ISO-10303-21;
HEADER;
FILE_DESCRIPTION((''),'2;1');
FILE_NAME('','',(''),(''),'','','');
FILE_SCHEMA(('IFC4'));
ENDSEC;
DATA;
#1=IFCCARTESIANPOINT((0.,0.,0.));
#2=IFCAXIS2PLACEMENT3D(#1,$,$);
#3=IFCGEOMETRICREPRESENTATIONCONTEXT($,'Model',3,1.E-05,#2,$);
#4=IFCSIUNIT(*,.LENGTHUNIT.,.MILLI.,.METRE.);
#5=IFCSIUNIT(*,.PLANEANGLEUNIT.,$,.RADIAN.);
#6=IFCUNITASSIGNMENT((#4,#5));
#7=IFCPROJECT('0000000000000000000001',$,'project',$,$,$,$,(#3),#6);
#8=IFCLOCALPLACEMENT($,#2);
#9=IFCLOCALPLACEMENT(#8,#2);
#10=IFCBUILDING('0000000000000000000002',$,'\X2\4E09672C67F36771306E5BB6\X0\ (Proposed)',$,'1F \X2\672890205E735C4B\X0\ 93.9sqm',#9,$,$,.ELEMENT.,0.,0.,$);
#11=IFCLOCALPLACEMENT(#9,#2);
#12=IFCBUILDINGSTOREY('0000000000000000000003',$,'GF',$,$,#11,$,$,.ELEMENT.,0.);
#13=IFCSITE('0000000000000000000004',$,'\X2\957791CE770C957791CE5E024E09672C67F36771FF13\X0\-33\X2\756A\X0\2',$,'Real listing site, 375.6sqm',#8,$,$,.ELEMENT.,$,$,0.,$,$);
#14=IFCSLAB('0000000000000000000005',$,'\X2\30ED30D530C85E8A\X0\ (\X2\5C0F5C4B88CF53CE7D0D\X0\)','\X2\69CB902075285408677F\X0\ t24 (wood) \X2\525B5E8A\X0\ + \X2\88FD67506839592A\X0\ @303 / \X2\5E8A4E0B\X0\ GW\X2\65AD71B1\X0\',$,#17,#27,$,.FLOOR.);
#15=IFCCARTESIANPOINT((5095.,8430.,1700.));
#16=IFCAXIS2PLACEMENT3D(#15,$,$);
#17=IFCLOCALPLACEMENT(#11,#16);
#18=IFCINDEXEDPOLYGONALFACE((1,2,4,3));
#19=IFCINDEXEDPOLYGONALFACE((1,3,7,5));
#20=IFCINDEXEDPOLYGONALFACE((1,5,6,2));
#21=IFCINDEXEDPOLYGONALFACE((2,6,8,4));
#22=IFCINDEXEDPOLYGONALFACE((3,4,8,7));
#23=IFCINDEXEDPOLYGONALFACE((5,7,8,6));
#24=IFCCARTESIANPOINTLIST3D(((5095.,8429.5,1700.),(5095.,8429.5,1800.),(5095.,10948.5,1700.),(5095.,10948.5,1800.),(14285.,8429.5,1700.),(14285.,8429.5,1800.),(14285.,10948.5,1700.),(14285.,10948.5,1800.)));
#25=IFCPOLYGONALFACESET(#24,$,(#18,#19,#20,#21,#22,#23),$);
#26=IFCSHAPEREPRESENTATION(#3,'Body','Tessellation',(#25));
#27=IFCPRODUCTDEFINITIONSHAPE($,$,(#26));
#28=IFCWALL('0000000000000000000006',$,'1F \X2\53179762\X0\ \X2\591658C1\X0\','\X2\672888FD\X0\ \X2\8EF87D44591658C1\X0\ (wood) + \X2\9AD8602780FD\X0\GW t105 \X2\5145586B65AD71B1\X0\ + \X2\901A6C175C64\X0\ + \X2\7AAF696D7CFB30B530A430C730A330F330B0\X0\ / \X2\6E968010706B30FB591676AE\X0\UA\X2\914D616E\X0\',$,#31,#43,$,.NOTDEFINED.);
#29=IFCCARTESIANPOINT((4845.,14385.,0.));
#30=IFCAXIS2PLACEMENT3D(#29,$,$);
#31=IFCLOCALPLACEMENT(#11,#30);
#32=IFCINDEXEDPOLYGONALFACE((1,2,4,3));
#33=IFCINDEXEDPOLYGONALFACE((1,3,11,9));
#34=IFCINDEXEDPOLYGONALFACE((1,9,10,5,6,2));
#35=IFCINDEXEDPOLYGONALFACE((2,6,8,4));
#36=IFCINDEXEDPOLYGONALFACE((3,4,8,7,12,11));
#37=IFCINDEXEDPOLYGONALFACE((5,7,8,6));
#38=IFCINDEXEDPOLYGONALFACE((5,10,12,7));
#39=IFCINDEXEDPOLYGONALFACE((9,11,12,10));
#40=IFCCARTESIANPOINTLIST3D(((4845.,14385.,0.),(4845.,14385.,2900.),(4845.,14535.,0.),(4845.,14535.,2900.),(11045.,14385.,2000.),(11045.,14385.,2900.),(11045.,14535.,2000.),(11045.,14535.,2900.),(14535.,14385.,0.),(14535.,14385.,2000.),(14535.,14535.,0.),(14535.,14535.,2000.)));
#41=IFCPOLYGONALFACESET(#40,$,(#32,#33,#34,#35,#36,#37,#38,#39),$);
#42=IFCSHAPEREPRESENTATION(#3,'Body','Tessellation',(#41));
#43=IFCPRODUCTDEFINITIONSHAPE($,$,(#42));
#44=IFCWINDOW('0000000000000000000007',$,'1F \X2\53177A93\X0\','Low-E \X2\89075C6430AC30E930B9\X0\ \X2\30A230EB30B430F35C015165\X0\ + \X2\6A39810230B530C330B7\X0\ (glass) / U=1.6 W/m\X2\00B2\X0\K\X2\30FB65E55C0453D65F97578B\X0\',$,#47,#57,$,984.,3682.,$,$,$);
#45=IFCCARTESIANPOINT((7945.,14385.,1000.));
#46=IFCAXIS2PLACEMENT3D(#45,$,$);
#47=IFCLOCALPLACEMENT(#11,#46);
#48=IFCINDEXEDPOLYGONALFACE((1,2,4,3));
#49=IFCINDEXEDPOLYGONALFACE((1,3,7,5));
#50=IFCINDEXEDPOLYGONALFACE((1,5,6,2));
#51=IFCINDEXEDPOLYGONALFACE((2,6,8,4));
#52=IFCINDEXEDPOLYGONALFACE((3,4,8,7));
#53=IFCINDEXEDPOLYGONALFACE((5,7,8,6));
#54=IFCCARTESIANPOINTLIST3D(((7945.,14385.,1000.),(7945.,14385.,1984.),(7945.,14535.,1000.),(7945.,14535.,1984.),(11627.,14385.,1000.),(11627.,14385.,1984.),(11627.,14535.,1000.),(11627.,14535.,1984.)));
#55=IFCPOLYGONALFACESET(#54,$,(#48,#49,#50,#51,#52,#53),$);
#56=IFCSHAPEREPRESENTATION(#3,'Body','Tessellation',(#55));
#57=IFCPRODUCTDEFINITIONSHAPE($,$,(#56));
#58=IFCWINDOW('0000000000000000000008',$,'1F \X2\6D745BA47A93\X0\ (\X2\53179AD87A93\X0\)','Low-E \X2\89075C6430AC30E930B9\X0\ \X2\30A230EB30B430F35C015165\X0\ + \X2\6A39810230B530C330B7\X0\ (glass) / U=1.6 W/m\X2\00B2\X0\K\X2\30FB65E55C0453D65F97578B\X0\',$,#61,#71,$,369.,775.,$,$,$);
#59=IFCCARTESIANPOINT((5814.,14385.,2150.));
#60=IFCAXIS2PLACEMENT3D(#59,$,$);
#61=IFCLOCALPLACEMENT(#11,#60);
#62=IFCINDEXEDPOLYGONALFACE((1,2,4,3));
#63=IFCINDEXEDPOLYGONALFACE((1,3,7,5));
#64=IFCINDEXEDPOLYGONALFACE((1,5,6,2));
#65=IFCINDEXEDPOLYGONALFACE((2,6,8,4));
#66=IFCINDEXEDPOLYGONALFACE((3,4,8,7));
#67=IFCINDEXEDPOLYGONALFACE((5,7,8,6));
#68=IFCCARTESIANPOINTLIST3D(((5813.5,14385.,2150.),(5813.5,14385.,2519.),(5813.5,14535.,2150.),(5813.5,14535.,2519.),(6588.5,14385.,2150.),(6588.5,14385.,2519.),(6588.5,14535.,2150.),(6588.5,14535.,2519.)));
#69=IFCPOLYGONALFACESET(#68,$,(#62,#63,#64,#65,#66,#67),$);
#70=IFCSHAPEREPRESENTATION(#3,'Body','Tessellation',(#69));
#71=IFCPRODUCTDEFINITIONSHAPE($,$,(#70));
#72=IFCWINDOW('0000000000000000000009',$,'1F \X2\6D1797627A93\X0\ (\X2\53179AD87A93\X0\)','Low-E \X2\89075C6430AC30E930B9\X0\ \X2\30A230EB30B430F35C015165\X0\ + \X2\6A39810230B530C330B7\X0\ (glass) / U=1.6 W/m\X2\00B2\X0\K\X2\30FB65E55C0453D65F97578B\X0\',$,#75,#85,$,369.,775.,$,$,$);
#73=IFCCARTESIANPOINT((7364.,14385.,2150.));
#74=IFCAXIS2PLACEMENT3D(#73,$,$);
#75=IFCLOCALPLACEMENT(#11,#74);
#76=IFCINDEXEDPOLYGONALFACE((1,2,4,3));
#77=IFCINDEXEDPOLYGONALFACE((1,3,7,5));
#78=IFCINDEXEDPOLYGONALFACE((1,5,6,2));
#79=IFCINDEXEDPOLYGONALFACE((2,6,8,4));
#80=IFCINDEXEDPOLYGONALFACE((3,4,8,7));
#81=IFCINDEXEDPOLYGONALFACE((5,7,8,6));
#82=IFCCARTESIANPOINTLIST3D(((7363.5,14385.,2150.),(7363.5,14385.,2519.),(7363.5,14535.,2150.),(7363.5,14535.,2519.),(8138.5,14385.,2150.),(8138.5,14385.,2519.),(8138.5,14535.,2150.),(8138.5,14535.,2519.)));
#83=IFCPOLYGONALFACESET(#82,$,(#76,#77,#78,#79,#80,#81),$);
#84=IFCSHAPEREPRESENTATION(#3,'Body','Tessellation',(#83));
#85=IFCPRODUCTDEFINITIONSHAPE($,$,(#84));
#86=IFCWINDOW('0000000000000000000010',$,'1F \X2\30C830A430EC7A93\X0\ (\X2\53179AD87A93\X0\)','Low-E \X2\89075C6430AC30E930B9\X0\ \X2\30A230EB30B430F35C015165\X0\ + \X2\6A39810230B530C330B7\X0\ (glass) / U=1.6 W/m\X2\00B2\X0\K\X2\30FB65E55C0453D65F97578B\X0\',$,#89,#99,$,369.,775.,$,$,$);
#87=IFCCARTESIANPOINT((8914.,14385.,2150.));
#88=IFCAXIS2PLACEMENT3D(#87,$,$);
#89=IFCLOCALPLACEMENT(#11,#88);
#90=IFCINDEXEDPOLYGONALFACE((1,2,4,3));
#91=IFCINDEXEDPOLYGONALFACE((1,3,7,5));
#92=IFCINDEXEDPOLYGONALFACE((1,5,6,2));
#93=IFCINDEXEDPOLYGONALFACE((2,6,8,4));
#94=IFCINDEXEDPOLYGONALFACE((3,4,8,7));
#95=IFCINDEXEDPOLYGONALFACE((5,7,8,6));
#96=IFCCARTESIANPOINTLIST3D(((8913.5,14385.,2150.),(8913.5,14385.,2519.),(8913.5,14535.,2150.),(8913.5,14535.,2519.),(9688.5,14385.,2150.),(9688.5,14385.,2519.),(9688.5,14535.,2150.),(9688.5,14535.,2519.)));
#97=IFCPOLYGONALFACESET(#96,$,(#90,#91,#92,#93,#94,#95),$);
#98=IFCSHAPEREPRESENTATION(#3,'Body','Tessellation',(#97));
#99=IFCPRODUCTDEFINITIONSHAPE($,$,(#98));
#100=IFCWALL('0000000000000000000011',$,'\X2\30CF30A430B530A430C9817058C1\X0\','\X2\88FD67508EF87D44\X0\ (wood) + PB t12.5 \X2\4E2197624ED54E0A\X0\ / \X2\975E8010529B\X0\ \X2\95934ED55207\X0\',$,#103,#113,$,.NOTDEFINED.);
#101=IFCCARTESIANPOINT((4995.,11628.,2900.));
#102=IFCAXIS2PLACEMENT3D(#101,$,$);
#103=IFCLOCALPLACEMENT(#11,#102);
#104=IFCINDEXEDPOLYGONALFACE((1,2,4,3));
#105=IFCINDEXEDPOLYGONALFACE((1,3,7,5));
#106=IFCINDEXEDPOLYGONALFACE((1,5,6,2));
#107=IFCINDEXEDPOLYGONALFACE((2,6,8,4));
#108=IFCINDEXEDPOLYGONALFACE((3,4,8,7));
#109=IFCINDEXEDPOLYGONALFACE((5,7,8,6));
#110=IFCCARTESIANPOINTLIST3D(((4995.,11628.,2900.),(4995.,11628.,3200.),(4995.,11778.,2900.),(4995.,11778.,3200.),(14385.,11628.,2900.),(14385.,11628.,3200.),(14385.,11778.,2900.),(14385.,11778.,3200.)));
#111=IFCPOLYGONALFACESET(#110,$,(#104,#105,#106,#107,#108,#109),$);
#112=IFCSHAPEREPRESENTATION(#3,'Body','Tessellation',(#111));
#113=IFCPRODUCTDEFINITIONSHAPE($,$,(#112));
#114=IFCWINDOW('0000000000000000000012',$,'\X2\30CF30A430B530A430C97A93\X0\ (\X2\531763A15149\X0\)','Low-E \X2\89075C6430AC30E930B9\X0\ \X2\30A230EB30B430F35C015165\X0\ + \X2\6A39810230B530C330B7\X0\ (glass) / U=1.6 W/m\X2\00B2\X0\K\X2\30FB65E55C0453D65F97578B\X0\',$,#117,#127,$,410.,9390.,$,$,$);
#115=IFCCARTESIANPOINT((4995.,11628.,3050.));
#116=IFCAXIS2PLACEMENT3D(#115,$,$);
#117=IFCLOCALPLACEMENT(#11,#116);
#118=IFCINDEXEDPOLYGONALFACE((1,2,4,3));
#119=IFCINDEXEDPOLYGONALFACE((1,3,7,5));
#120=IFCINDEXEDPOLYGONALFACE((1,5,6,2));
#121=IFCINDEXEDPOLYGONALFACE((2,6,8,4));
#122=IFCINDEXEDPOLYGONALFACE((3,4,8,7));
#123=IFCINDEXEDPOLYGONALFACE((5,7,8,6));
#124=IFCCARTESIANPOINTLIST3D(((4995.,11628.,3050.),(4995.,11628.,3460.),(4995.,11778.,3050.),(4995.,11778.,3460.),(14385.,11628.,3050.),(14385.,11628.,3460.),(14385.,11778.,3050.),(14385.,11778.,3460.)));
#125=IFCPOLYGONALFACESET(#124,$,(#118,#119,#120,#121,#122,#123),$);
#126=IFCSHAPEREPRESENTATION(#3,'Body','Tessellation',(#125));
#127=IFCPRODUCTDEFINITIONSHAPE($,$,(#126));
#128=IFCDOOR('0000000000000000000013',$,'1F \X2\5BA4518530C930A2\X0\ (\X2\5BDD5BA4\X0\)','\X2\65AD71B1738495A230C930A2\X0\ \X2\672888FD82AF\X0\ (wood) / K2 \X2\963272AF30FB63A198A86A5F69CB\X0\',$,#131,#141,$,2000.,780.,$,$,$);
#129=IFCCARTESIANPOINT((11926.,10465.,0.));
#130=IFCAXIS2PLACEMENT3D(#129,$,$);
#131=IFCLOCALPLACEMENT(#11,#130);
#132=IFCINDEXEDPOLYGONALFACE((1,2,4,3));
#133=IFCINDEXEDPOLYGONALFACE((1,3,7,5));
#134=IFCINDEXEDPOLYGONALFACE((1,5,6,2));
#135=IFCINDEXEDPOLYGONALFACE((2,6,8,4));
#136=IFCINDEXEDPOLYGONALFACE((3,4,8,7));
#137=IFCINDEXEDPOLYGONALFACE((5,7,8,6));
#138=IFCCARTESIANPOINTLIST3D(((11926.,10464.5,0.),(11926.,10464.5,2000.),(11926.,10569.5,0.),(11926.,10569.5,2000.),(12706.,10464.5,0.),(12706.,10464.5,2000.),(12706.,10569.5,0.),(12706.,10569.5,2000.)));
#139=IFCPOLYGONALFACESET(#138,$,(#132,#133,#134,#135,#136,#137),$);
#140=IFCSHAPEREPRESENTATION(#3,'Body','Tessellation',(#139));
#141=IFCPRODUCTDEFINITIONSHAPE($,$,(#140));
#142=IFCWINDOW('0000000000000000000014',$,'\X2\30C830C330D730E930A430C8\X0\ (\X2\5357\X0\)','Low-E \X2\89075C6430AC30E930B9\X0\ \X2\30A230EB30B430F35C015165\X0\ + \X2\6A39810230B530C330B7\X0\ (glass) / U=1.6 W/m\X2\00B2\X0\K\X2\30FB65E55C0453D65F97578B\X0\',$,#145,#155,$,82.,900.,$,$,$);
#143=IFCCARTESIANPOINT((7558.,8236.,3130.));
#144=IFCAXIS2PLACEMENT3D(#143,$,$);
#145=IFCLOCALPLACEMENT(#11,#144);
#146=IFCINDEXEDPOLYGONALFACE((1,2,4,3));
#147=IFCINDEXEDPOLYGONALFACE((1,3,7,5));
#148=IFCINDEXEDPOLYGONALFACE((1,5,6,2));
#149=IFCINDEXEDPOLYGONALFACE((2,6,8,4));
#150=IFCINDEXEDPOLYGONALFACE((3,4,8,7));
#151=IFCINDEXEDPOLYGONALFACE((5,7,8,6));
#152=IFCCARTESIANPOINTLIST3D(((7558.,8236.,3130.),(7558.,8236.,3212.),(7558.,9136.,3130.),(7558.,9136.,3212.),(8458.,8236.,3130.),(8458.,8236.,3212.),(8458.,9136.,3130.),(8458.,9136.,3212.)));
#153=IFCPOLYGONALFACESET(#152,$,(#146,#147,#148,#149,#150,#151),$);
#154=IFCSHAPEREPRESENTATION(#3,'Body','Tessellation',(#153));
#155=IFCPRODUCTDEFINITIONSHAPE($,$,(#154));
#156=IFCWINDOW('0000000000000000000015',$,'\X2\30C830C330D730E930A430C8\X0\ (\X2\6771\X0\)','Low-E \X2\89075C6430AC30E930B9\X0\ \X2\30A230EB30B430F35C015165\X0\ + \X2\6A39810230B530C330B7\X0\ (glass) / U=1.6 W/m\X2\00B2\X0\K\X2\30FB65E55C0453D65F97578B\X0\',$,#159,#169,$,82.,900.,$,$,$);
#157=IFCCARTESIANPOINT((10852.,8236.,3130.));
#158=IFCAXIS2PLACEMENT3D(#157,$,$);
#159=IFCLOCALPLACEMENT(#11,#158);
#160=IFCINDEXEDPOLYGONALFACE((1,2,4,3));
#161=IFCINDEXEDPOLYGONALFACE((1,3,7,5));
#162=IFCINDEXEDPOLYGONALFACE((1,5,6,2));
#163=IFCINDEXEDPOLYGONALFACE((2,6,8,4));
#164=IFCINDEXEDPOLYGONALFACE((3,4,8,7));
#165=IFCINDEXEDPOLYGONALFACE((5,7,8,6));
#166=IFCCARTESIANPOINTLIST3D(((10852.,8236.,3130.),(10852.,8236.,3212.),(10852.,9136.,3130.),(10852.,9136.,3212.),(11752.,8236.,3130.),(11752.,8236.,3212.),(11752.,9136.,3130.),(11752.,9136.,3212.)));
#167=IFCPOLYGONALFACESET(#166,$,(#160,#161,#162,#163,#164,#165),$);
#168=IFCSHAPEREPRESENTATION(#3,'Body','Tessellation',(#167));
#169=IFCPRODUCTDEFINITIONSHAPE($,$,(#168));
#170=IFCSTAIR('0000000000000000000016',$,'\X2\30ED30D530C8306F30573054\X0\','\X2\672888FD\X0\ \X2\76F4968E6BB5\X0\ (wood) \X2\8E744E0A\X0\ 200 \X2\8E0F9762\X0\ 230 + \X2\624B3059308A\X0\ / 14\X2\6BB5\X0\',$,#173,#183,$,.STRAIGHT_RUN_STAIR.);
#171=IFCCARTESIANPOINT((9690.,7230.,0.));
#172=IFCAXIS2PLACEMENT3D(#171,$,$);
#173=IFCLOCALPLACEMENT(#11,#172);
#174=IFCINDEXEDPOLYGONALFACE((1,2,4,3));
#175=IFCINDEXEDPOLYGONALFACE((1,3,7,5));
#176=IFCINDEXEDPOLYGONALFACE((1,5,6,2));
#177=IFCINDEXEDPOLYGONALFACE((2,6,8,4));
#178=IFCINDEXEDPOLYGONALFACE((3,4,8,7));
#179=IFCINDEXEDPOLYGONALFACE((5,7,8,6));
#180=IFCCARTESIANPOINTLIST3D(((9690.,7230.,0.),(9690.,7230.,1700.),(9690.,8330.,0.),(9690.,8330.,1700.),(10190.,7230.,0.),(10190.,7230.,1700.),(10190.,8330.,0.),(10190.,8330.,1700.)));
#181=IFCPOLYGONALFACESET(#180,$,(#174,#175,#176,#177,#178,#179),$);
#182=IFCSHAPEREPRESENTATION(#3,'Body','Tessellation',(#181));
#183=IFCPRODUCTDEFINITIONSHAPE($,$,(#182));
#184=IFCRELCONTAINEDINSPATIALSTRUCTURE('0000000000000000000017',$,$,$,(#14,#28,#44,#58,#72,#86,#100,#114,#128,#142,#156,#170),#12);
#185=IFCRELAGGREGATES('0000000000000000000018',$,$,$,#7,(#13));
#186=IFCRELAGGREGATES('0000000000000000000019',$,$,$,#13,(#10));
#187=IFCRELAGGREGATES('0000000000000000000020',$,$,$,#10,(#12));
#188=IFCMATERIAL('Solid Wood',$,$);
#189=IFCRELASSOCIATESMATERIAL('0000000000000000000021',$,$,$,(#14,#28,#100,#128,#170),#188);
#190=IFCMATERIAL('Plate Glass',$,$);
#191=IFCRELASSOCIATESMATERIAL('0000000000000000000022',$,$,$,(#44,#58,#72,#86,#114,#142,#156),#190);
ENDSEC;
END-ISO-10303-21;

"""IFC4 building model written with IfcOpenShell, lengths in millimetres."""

from ifc_helpers import new_model, si_unit, frame, frame_2d, origin, place, context, project, spatial, rectangle, extrude, material, element, fill, save


model = new_model("IFC4")

# Units and contexts
model_context = context("Model", 3, precision=1e-05, world=origin())
ifc_project = project(units=[si_unit("LENGTHUNIT", "METRE", prefix="MILLI"), si_unit("PLANEANGLEUNIT", "RADIAN")], contexts=[model_context])

# Site, building, storey
site_placement = place(None, origin())
site = spatial("IfcSite", under=ifc_project, at=site_placement, Name="長野県長野市三本柳東３-33番2", ObjectType="Real listing site, 375.6sqm", CompositionType="ELEMENT", RefElevation=0.0)
building_placement = place(site_placement, origin())
building = spatial("IfcBuilding", under=site, at=building_placement, Name="三本柳東の家 (Proposed)", ObjectType="1F 木造平屋 93.9sqm", CompositionType="ELEMENT", ElevationOfRefHeight=0.0, ElevationOfTerrain=0.0)
storey_placement = place(building_placement, origin())
storey = spatial("IfcBuildingStorey", under=building, at=storey_placement, Name="GF", CompositionType="ELEMENT", Elevation=0.0)

# Slab
ifc_material_1 = material(Name="Solid Wood")
slab_placement = place(storey_placement, frame((5095.0, 8430.0, 1700.0)))
element("IfcSlab", 1, at=slab_placement, inside=storey, material=ifc_material_1, Name="ロフト床 (小屋裏収納)", Description="構造用合板 t24 (wood) 剛床 + 製材根太 @303 / 床下 GW断熱", PredefinedType="FLOOR", context=model_context, shape_type="SweptSolid", body=[
    extrude(rectangle(XDim=9190.0, YDim=2519.0, at=frame_2d((4595.0, 1259.0))), frame((5095.0, 8430.0, 1700.0)), (0.0, 0.0, 1.0), 100.0),
])

# Wall, openings, windows
wall_1_placement = place(storey_placement, frame((4845.0, 14385.0, 0.0)))
wall_1 = element("IfcWall", 2, at=wall_1_placement, inside=storey, material=ifc_material_1, Name="1F 北面 外壁", Description="木製 軸組外壁 (wood) + 高性能GW t105 充填断熱 + 通気層 + 窯業系サイディング / 準耐火・外皮UA配慮", PredefinedType="NOTDEFINED", context=model_context, shape_type="SweptSolid", body=[
    extrude(rectangle(XDim=9690.0, YDim=150.0, at=frame_2d((4845.0, 75.0))), frame((4845.0, 14385.0, 0.0)), (0.0, 0.0, 1.0), 2900.0),
])
opening_1_placement = place(storey_placement, frame((7945.0, 14385.0, 1000.0)))
opening_1 = element("IfcOpeningElement", 3, at=opening_1_placement, cuts=wall_1, PredefinedType="NOTDEFINED", context=model_context, shape_type="SweptSolid", body=[
    extrude(rectangle(XDim=3682.0, YDim=150.0, at=frame_2d((1841.0, 75.0))), frame((7945.0, 14385.0, 1000.0)), (0.0, 0.0, 1.0), 984.0),
])
opening_2_placement = place(storey_placement, frame((5814.0, 14385.0, 2150.0)))
opening_2 = element("IfcOpeningElement", 4, at=opening_2_placement, cuts=wall_1, PredefinedType="NOTDEFINED", context=model_context, shape_type="SweptSolid", body=[
    extrude(rectangle(XDim=775.0, YDim=150.0, at=frame_2d((387.0, 75.0))), frame((5814.0, 14385.0, 2150.0)), (0.0, 0.0, 1.0), 369.0),
])
opening_3_placement = place(storey_placement, frame((7364.0, 14385.0, 2150.0)))
opening_3 = element("IfcOpeningElement", 5, at=opening_3_placement, cuts=wall_1, PredefinedType="NOTDEFINED", context=model_context, shape_type="SweptSolid", body=[
    extrude(rectangle(XDim=775.0, YDim=150.0, at=frame_2d((387.0, 75.0))), frame((7364.0, 14385.0, 2150.0)), (0.0, 0.0, 1.0), 369.0),
])
opening_4_placement = place(storey_placement, frame((8914.0, 14385.0, 2150.0)))
opening_4 = element("IfcOpeningElement", 6, at=opening_4_placement, cuts=wall_1, PredefinedType="NOTDEFINED", context=model_context, shape_type="SweptSolid", body=[
    extrude(rectangle(XDim=775.0, YDim=150.0, at=frame_2d((387.0, 75.0))), frame((8914.0, 14385.0, 2150.0)), (0.0, 0.0, 1.0), 369.0),
])
ifc_material_2 = material(Name="Plate Glass")
window_1_placement = place(storey_placement, frame((7945.0, 14385.0, 1000.0)))
window_1 = element("IfcWindow", 7, at=window_1_placement, inside=storey, material=ifc_material_2, Name="1F 北窓", Description="Low-E 複層ガラス アルゴン封入 + 樹脂サッシ (glass) / U=1.6 W/m²K・日射取得型", OverallHeight=984.0, OverallWidth=3682.0, context=model_context, shape_type="SweptSolid", body=[
    extrude(rectangle(XDim=3682.0, YDim=150.0, at=frame_2d((1841.0, 75.0))), frame((7945.0, 14385.0, 1000.0)), (0.0, 0.0, 1.0), 984.0),
])
fill(opening_1, window_1)
window_2_placement = place(storey_placement, frame((5814.0, 14385.0, 2150.0)))
window_2 = element("IfcWindow", 8, at=window_2_placement, inside=storey, material=ifc_material_2, Name="1F 浴室窓 (北高窓)", Description="Low-E 複層ガラス アルゴン封入 + 樹脂サッシ (glass) / U=1.6 W/m²K・日射取得型", OverallHeight=369.0, OverallWidth=775.0, context=model_context, shape_type="SweptSolid", body=[
    extrude(rectangle(XDim=775.0, YDim=150.0, at=frame_2d((387.0, 75.0))), frame((5814.0, 14385.0, 2150.0)), (0.0, 0.0, 1.0), 369.0),
])
fill(opening_2, window_2)
window_3_placement = place(storey_placement, frame((7364.0, 14385.0, 2150.0)))
window_3 = element("IfcWindow", 9, at=window_3_placement, inside=storey, material=ifc_material_2, Name="1F 洗面窓 (北高窓)", Description="Low-E 複層ガラス アルゴン封入 + 樹脂サッシ (glass) / U=1.6 W/m²K・日射取得型", OverallHeight=369.0, OverallWidth=775.0, context=model_context, shape_type="SweptSolid", body=[
    extrude(rectangle(XDim=775.0, YDim=150.0, at=frame_2d((387.0, 75.0))), frame((7364.0, 14385.0, 2150.0)), (0.0, 0.0, 1.0), 369.0),
])
fill(opening_3, window_3)
window_4_placement = place(storey_placement, frame((8914.0, 14385.0, 2150.0)))
window_4 = element("IfcWindow", 10, at=window_4_placement, inside=storey, material=ifc_material_2, Name="1F トイレ窓 (北高窓)", Description="Low-E 複層ガラス アルゴン封入 + 樹脂サッシ (glass) / U=1.6 W/m²K・日射取得型", OverallHeight=369.0, OverallWidth=775.0, context=model_context, shape_type="SweptSolid", body=[
    extrude(rectangle(XDim=775.0, YDim=150.0, at=frame_2d((387.0, 75.0))), frame((8914.0, 14385.0, 2150.0)), (0.0, 0.0, 1.0), 369.0),
])
fill(opening_4, window_4)

# Wall, opening, window
wall_2_placement = place(storey_placement, frame((4995.0, 11628.0, 2900.0)))
wall_2 = element("IfcWall", 11, at=wall_2_placement, inside=storey, material=ifc_material_1, Name="ハイサイド腰壁", Description="製材軸組 (wood) + PB t12.5 両面仕上 / 非耐力 間仕切", PredefinedType="NOTDEFINED", context=model_context, shape_type="SweptSolid", body=[
    extrude(rectangle(XDim=9390.0, YDim=150.0, at=frame_2d((4695.0, 75.0))), frame((4995.0, 11628.0, 2900.0)), (0.0, 0.0, 1.0), 700.0),
])
opening_5_placement = place(storey_placement, frame((4995.0, 11628.0, 3050.0)))
opening_5 = element("IfcOpeningElement", 12, at=opening_5_placement, cuts=wall_2, PredefinedType="NOTDEFINED", context=model_context, shape_type="SweptSolid", body=[
    extrude(rectangle(XDim=9390.0, YDim=150.0, at=frame_2d((4695.0, 75.0))), frame((4995.0, 11628.0, 3050.0)), (0.0, 0.0, 1.0), 410.0),
])
window_5_placement = place(storey_placement, frame((4995.0, 11628.0, 3050.0)))
window_5 = element("IfcWindow", 13, at=window_5_placement, inside=storey, material=ifc_material_2, Name="ハイサイド窓 (北採光)", Description="Low-E 複層ガラス アルゴン封入 + 樹脂サッシ (glass) / U=1.6 W/m²K・日射取得型", OverallHeight=410.0, OverallWidth=9390.0, context=model_context, shape_type="SweptSolid", body=[
    extrude(rectangle(XDim=9390.0, YDim=150.0, at=frame_2d((4695.0, 75.0))), frame((4995.0, 11628.0, 3050.0)), (0.0, 0.0, 1.0), 410.0),
])
fill(opening_5, window_5)

# Door
door_1_placement = place(storey_placement, frame((11926.0, 10465.0, 0.0)))
element("IfcDoor", 14, at=door_1_placement, inside=storey, material=ifc_material_1, Name="1F 室内ドア (寝室)", Description="断熱玄関ドア 木製芯 (wood) / K2 防犯・採風機構", OverallHeight=2000.0, OverallWidth=780.0, context=model_context, shape_type="SweptSolid", body=[
    extrude(rectangle(XDim=780.0, YDim=105.0, at=frame_2d((390.0, 52.0))), frame((11926.0, 10465.0, 0.0)), (0.0, 0.0, 1.0), 2000.0),
])

# Windows
window_6_placement = place(storey_placement, frame((7558.0, 8236.0, 3130.0)))
element("IfcWindow", 15, at=window_6_placement, inside=storey, material=ifc_material_2, Name="トップライト (南)", Description="Low-E 複層ガラス アルゴン封入 + 樹脂サッシ (glass) / U=1.6 W/m²K・日射取得型", OverallHeight=82.0, OverallWidth=900.0, context=model_context, shape_type="SweptSolid", body=[
    extrude(rectangle(XDim=900.0, YDim=900.0, at=frame_2d((450.0, 450.0))), frame((7558.0, 8236.0, 3130.0)), (0.0, 0.0, 1.0), 82.0),
])
window_7_placement = place(storey_placement, frame((10852.0, 8236.0, 3130.0)))
element("IfcWindow", 16, at=window_7_placement, inside=storey, material=ifc_material_2, Name="トップライト (東)", Description="Low-E 複層ガラス アルゴン封入 + 樹脂サッシ (glass) / U=1.6 W/m²K・日射取得型", OverallHeight=82.0, OverallWidth=900.0, context=model_context, shape_type="SweptSolid", body=[
    extrude(rectangle(XDim=900.0, YDim=900.0, at=frame_2d((450.0, 450.0))), frame((10852.0, 8236.0, 3130.0)), (0.0, 0.0, 1.0), 82.0),
])

# Stair
stair_placement = place(storey_placement, frame((9690.0, 7230.0, 0.0)))
element("IfcStair", 17, at=stair_placement, inside=storey, material=ifc_material_1, Name="ロフトはしご", Description="木製 直階段 (wood) 蹴上 200 踏面 230 + 手すり / 14段", PredefinedType="STRAIGHT_RUN_STAIR", context=model_context, shape_type="SweptSolid", body=[
    extrude(rectangle(XDim=500.0, YDim=1100.0, at=frame_2d((250.0, 550.0))), frame((9690.0, 7230.0, 0.0)), (0.0, 0.0, 1.0), 1700.0),
])

save(model, "model.ifc")
